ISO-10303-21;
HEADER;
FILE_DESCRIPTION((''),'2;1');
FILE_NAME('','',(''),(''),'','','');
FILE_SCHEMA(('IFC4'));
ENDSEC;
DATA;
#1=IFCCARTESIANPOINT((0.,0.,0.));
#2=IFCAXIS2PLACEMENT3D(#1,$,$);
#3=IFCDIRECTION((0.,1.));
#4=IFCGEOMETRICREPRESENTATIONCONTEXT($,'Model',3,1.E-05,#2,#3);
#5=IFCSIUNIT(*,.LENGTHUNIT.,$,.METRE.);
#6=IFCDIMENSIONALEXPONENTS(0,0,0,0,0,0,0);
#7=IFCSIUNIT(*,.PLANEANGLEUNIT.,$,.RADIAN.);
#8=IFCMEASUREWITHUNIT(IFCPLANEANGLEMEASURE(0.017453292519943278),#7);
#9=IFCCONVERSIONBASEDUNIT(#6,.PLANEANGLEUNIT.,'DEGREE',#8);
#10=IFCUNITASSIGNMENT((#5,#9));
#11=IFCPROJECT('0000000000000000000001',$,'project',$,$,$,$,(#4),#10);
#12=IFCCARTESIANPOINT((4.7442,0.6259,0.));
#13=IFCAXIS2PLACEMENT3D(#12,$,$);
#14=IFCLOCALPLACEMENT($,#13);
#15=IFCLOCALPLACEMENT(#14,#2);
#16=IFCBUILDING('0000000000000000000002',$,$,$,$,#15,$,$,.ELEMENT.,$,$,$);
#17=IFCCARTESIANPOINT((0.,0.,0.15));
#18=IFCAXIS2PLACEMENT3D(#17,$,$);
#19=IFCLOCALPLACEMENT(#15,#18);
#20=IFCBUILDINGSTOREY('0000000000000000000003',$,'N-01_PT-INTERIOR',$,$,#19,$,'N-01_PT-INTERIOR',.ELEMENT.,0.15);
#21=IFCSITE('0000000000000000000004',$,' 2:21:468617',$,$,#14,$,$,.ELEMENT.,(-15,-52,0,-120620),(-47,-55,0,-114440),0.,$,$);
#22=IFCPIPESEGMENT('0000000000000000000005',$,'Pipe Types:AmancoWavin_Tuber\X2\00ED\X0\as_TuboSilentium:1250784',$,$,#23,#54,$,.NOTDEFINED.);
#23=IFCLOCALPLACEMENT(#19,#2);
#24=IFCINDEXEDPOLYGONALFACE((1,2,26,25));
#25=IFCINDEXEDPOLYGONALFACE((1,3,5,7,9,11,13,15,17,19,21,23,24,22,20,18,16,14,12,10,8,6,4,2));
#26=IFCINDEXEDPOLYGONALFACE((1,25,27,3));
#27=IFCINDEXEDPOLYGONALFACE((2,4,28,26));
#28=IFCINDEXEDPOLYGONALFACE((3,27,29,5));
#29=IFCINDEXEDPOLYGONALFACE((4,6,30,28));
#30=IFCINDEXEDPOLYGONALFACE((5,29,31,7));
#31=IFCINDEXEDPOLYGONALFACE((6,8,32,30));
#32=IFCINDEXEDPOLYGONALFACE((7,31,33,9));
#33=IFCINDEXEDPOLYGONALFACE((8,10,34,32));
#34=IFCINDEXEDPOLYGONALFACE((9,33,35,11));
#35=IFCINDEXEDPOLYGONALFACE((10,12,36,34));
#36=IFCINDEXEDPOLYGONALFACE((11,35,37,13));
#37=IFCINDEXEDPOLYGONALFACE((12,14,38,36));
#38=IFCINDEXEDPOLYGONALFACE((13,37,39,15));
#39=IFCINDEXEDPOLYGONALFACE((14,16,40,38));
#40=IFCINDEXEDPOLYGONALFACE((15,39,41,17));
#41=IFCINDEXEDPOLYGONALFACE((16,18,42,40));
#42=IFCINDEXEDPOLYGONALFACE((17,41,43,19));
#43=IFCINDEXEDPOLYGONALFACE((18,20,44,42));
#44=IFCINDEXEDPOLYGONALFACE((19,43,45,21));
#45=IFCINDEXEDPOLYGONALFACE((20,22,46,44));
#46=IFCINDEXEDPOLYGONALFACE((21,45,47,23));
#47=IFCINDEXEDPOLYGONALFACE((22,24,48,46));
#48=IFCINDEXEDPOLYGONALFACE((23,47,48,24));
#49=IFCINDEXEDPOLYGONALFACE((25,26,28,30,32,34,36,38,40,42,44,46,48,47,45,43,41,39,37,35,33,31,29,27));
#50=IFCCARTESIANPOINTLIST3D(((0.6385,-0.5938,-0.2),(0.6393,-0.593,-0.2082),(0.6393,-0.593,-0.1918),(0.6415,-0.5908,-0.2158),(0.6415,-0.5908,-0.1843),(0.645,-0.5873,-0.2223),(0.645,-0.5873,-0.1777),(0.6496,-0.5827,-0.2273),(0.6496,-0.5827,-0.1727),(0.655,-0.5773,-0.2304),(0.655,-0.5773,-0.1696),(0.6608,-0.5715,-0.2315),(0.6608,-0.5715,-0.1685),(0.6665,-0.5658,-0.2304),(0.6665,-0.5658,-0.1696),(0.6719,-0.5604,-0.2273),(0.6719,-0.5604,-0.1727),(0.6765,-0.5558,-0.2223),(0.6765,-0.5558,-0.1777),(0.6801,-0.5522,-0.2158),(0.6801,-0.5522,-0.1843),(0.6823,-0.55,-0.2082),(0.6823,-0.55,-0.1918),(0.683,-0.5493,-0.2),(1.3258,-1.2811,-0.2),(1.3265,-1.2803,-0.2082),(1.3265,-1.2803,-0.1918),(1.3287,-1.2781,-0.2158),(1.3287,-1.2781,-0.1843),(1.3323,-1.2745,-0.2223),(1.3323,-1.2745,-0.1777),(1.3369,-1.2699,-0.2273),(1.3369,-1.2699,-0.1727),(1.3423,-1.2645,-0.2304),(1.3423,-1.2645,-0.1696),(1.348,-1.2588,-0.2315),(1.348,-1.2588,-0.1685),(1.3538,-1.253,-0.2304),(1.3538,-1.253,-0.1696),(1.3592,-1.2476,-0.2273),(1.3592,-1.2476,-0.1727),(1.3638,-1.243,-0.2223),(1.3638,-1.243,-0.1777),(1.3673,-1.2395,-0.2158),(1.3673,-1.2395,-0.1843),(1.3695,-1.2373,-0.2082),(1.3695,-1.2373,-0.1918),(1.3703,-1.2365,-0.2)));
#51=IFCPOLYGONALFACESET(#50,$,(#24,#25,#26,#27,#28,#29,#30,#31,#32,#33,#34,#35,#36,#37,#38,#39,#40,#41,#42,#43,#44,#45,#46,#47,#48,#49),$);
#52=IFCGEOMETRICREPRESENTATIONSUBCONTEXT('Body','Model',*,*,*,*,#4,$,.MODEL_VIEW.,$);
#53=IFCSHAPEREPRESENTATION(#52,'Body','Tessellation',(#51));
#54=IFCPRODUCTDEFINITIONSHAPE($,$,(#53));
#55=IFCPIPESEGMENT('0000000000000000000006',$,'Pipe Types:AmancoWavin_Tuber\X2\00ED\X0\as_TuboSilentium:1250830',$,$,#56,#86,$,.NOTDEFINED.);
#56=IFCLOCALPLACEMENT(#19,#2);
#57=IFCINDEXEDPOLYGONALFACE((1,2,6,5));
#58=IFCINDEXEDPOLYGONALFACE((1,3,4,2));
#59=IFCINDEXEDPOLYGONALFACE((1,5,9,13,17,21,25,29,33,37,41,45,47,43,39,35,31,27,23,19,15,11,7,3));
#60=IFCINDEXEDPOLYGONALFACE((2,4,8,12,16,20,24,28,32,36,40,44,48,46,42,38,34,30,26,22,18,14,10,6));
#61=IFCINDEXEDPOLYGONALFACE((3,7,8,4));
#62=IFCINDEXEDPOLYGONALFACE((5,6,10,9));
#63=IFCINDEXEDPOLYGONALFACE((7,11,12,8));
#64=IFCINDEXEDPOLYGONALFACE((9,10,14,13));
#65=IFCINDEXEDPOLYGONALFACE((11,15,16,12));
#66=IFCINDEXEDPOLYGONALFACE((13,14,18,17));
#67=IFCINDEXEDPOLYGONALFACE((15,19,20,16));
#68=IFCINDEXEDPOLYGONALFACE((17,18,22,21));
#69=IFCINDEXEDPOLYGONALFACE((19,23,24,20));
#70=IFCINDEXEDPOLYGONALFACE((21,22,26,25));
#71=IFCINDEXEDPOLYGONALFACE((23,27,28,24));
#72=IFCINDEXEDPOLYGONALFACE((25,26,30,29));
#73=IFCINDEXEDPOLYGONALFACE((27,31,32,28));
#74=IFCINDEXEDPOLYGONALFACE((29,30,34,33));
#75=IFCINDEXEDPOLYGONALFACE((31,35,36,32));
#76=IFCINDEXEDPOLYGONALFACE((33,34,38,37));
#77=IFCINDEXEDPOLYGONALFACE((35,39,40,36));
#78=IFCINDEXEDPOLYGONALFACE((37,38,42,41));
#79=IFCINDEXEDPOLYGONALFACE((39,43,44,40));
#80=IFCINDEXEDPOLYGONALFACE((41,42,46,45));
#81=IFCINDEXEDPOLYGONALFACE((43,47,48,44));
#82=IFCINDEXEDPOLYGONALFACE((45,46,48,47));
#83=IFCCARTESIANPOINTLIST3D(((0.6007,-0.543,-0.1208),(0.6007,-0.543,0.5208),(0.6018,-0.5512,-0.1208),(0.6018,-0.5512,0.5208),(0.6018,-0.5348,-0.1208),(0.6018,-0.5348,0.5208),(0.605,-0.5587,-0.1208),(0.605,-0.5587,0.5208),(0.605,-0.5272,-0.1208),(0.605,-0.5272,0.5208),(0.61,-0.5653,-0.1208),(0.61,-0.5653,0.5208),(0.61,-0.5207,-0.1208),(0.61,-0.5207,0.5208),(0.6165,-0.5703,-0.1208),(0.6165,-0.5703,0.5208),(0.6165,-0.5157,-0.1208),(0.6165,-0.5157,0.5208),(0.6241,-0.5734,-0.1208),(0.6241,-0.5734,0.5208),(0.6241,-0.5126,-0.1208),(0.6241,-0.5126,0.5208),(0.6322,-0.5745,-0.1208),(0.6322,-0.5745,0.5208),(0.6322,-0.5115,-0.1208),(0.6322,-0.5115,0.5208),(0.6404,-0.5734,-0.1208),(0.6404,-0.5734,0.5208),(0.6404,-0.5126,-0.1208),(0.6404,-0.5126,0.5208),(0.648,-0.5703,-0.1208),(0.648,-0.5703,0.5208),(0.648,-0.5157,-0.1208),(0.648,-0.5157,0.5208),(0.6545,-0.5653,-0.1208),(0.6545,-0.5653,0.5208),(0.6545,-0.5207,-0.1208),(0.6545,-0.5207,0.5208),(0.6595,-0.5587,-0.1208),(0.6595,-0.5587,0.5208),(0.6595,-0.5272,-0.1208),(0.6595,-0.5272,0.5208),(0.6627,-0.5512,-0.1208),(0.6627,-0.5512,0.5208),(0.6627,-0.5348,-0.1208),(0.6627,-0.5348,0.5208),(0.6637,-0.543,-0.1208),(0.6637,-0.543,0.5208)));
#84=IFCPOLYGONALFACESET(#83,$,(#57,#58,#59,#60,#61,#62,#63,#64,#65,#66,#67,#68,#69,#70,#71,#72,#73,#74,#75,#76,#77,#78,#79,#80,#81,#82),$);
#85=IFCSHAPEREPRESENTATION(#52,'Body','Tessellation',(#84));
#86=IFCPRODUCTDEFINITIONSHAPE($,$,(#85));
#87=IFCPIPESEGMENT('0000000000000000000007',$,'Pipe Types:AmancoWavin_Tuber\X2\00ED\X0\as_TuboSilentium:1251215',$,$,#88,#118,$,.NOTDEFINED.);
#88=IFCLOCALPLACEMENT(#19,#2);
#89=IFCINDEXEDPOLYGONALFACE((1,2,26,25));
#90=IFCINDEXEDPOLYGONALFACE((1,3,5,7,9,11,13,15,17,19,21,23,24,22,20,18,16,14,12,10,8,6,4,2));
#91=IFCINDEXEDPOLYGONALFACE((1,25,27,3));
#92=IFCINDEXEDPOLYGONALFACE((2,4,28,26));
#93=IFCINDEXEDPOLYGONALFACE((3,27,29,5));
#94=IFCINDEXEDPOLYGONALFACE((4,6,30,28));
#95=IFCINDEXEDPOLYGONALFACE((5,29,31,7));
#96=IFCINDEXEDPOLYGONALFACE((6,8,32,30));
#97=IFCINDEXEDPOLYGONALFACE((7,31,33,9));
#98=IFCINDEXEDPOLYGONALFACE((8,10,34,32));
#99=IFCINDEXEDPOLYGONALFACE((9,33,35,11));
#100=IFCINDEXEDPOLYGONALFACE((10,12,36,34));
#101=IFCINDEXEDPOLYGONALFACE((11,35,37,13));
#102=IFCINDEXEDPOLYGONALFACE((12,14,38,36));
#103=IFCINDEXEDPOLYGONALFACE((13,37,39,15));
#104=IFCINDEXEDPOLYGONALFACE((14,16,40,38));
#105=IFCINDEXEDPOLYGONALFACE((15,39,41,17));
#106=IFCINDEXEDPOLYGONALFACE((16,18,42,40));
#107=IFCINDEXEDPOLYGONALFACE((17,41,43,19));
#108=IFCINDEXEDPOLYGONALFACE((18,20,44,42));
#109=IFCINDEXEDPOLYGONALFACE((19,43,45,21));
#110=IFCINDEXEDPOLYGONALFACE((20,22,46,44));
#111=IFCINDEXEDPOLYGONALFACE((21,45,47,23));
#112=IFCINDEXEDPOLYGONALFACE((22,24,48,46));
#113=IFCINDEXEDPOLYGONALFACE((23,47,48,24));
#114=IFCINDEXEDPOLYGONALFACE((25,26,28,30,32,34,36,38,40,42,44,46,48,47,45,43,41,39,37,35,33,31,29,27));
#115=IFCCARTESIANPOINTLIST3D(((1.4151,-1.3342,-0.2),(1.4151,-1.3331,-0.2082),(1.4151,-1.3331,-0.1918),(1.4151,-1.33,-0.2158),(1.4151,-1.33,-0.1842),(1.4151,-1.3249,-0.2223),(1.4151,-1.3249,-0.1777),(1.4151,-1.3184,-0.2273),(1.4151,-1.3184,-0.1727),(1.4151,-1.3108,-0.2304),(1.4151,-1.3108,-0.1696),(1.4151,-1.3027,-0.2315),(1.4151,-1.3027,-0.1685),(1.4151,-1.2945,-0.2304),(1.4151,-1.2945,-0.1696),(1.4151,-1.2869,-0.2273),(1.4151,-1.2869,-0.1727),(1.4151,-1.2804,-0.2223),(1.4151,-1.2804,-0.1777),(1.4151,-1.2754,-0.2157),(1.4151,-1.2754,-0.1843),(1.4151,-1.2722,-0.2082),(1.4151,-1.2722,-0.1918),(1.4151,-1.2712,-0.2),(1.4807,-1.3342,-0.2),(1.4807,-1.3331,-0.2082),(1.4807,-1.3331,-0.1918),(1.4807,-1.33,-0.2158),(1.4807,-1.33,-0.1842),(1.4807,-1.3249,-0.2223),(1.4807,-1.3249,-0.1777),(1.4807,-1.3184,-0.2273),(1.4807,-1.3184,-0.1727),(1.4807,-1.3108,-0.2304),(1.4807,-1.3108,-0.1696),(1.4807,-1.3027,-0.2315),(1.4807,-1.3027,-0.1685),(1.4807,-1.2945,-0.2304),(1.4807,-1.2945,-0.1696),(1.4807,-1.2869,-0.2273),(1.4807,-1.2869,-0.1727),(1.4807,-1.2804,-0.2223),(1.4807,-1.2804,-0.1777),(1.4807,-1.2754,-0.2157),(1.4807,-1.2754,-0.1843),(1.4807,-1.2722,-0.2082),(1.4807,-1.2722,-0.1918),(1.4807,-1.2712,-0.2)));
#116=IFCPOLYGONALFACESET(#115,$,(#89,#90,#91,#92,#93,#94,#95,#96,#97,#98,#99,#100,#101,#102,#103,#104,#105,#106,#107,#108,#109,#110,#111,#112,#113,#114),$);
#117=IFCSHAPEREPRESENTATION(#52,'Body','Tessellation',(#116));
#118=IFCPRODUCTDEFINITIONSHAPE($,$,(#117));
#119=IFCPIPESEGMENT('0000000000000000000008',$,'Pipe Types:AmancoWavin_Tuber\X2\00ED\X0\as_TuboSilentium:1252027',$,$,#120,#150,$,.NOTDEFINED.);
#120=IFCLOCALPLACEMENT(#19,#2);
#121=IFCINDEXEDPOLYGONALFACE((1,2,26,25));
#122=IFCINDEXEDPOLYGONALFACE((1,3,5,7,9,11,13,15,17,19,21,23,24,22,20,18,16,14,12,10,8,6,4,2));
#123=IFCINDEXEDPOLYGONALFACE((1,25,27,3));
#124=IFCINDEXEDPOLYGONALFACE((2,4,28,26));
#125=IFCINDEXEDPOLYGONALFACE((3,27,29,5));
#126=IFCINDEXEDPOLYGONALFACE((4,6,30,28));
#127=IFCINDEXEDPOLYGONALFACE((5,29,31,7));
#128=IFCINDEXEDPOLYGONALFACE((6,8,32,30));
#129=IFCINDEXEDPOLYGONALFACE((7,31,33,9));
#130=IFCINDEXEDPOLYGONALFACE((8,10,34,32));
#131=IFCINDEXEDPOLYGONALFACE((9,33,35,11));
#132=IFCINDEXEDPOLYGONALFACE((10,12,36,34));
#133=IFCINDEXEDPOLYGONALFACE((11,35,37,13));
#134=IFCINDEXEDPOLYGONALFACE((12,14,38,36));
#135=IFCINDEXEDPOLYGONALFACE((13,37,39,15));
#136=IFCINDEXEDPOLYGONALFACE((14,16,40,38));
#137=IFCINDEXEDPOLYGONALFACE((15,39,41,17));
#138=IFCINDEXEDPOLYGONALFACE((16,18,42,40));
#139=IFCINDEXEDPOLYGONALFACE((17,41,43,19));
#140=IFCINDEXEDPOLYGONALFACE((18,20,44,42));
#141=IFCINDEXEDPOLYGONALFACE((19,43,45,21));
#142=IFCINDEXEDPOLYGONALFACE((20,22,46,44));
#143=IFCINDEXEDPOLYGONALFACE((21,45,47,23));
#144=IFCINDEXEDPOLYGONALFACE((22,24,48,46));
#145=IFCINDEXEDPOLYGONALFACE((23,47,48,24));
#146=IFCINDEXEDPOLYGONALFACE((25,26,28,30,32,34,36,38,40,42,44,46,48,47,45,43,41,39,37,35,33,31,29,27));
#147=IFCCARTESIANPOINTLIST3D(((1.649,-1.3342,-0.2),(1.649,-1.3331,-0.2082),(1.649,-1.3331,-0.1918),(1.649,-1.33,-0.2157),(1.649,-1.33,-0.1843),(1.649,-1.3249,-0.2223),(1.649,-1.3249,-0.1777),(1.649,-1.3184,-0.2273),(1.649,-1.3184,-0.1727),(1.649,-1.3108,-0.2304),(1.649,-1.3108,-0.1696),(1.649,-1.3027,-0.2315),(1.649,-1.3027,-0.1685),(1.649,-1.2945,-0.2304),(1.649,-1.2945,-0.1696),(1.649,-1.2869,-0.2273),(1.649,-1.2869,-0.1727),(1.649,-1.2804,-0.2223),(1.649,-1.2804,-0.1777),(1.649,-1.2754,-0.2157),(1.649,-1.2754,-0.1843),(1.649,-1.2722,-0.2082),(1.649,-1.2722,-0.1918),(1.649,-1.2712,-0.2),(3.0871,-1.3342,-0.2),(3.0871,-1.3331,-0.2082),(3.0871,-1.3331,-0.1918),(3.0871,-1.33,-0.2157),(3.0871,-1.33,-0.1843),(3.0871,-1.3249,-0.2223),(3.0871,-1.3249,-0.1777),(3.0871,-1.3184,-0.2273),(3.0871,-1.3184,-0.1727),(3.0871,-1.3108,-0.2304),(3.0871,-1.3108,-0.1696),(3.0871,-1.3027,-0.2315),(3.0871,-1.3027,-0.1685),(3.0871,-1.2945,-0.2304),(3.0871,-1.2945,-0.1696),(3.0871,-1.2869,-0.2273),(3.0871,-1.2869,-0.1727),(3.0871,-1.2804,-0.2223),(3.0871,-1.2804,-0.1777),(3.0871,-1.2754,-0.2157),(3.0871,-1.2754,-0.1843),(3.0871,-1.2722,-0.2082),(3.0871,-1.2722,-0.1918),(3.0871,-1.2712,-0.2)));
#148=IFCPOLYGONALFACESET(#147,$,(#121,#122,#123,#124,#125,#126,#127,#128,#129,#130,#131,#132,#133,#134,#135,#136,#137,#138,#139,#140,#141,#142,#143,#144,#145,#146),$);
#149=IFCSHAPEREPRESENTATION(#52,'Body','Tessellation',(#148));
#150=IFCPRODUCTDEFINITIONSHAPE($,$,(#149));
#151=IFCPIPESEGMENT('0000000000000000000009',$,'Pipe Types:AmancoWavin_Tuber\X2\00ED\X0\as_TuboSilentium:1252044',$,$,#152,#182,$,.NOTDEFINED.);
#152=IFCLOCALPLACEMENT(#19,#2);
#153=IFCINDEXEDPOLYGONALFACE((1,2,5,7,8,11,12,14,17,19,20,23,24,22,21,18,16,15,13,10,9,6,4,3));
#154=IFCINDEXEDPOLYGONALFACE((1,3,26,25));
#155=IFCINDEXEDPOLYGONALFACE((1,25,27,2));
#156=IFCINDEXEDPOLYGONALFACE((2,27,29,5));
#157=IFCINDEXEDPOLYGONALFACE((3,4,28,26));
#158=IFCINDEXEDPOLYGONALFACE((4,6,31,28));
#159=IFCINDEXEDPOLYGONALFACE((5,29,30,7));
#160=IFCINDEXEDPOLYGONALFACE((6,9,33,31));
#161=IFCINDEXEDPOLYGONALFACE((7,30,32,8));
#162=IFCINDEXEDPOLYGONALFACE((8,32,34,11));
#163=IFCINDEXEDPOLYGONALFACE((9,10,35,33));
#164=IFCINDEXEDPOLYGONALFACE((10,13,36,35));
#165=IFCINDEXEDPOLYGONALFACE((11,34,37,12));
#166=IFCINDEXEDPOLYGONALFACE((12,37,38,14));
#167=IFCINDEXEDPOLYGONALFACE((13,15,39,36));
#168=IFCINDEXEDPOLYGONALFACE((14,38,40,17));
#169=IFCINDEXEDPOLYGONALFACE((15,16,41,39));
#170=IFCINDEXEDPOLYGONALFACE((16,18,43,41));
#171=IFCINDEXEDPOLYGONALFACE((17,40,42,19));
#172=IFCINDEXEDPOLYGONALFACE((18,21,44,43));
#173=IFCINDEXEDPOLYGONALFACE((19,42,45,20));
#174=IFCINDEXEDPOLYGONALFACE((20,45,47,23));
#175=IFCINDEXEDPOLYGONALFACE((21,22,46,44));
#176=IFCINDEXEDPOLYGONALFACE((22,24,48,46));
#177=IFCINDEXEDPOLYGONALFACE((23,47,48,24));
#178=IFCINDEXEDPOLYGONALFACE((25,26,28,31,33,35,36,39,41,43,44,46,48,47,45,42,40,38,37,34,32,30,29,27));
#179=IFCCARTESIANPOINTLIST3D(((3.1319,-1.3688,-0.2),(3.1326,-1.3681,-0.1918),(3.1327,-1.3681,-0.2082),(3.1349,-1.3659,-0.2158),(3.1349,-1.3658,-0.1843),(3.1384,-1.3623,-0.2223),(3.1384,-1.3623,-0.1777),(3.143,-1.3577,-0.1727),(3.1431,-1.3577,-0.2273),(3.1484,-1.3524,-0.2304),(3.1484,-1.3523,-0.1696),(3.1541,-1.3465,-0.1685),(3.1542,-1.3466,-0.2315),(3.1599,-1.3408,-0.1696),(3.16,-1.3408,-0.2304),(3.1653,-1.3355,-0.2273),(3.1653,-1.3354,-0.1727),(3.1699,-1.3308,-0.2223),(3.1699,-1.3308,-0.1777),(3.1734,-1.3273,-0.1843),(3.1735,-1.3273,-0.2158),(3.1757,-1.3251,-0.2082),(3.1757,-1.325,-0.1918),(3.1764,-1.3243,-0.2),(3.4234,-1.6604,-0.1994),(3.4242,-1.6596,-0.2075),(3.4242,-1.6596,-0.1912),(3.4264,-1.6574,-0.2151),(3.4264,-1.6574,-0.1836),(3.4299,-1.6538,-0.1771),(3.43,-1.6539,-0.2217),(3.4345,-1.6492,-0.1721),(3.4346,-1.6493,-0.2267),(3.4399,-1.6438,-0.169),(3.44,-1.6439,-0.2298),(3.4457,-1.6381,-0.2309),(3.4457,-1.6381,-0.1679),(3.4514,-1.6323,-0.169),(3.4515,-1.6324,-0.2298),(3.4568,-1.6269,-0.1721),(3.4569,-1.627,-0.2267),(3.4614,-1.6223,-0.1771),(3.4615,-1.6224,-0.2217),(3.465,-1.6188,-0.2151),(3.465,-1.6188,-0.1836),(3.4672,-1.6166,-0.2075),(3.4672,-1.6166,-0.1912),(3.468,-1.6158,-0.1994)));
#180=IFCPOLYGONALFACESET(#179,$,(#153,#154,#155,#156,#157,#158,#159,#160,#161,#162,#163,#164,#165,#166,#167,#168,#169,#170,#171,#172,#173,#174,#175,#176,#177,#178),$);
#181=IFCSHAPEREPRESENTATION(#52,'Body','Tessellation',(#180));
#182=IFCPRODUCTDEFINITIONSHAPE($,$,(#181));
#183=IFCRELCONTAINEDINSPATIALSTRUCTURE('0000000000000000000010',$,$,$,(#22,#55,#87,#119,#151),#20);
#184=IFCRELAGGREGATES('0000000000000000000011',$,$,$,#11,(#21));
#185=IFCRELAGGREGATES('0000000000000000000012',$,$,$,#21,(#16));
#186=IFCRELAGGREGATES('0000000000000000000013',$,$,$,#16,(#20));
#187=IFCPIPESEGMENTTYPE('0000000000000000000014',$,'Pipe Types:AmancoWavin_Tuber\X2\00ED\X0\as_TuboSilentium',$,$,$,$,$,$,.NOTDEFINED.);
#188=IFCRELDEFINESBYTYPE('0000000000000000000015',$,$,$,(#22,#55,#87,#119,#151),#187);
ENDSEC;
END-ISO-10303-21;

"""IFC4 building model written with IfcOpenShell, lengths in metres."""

from ifc_helpers import new_model, entity, si_unit, converted_unit, direction, frame, origin, place, context, subcontext, project, spatial, arc, indexed_curve, outline, extrude, type_object, element, save


model = new_model("IFC4")

# Units and contexts
model_context = context("Model", 3, precision=1e-05, world=origin(), true_north=direction((0.0, 1.0)))
body_context = subcontext(model_context, "Body", "Model", "MODEL_VIEW")
ifc_project = project(units=[si_unit("LENGTHUNIT", "METRE"), converted_unit("PLANEANGLEUNIT", "DEGREE", entity("IfcPlaneAngleMeasure", 0.017453292519943278), si_unit("PLANEANGLEUNIT", "RADIAN"), dimensions=[0, 0, 0, 0, 0, 0, 0])], contexts=[model_context])

# Site, building, storey
site_placement = place(None, frame((4.7442, 0.6259, 0.0)))
site = spatial("IfcSite", under=ifc_project, at=site_placement, Name=" 2:21:468617", CompositionType="ELEMENT", RefLatitude=(-15, -52, 0, -120620), RefLongitude=(-47, -55, 0, -114440), RefElevation=0.0)
building_placement = place(site_placement, origin())
building = spatial("IfcBuilding", under=site, at=building_placement, CompositionType="ELEMENT")
storey_placement = place(building_placement, frame((0.0, 0.0, 0.15)))
storey = spatial("IfcBuildingStorey", under=building, at=storey_placement, Name="N-01_PT-INTERIOR", LongName="N-01_PT-INTERIOR", CompositionType="ELEMENT", Elevation=0.15)

# Pipe segments
pipe_segment_type_1 = type_object("IfcPipeSegmentType", Name="Pipe Types:AmancoWavin_Tuberías_TuboSilentium", PredefinedType="NOTDEFINED")
pipe_segment_1_placement = place(storey_placement, origin())
element("IfcPipeSegment", 1, at=pipe_segment_1_placement, inside=storey, type_object=pipe_segment_type_1, Name="Pipe Types:AmancoWavin_Tuberías_TuboSilentium:1250784", PredefinedType="NOTDEFINED", context=body_context, shape_type="SweptSolid", body=[
    extrude(outline(indexed_curve([(0.0315, 0.0), (0.0223, 0.0223), (0.0, 0.0315), (-0.0223, 0.0223), (-0.0315, 0.0), (-0.0223, -0.0223), (0.0, -0.0315), (0.0223, -0.0223)], segments=[arc(1, 2, 3), arc(3, 4, 5), arc(5, 6, 7), arc(7, 8, 1)], self_intersect=False)), frame((1.348, -1.2588, -0.2), z_axis=(-0.707107, 0.707107, 0.0), x_axis=(0.707107, 0.707107, 0.0)), (0.0, 0.0, 1.0), 0.9719),
])
pipe_segment_2_placement = place(storey_placement, origin())
element("IfcPipeSegment", 2, at=pipe_segment_2_placement, inside=storey, type_object=pipe_segment_type_1, Name="Pipe Types:AmancoWavin_Tuberías_TuboSilentium:1250830", PredefinedType="NOTDEFINED", context=body_context, shape_type="SweptSolid", body=[
    extrude(outline(indexed_curve([(0.0315, 0.0), (0.0223, 0.0223), (0.0, 0.0315), (-0.0223, 0.0223), (-0.0315, 0.0), (-0.0223, -0.0223), (0.0, -0.0315), (0.0223, -0.0223)], segments=[arc(1, 2, 3), arc(3, 4, 5), arc(5, 6, 7), arc(7, 8, 1)], self_intersect=False)), frame((0.6322, -0.543, -0.1208), z_axis=(0.0, 0.0, 1.0), x_axis=(-1.0, 0.0, 0.0)), (0.0, 0.0, 1.0), 0.6416),
])
pipe_segment_3_placement = place(storey_placement, origin())
element("IfcPipeSegment", 3, at=pipe_segment_3_placement, inside=storey, type_object=pipe_segment_type_1, Name="Pipe Types:AmancoWavin_Tuberías_TuboSilentium:1251215", PredefinedType="NOTDEFINED", context=body_context, shape_type="SweptSolid", body=[
    extrude(outline(indexed_curve([(0.0315, 0.0), (0.0223, 0.0223), (0.0, 0.0315), (-0.0223, 0.0223), (-0.0315, 0.0), (-0.0223, -0.0223), (0.0, -0.0315), (0.0223, -0.0223)], segments=[arc(1, 2, 3), arc(3, 4, 5), arc(5, 6, 7), arc(7, 8, 1)], self_intersect=False)), frame((1.4151, -1.3027, -0.2), z_axis=(1.0, 0.0, 0.0), x_axis=(0.0, 1.0, 0.0)), (0.0, 0.0, 1.0), 0.0656),
])
pipe_segment_4_placement = place(storey_placement, origin())
element("IfcPipeSegment", 4, at=pipe_segment_4_placement, inside=storey, type_object=pipe_segment_type_1, Name="Pipe Types:AmancoWavin_Tuberías_TuboSilentium:1252027", PredefinedType="NOTDEFINED", context=body_context, shape_type="SweptSolid", body=[
    extrude(outline(indexed_curve([(0.0315, 0.0), (0.0223, 0.0223), (0.0, 0.0315), (-0.0223, 0.0223), (-0.0315, 0.0), (-0.0223, -0.0223), (0.0, -0.0315), (0.0223, -0.0223)], segments=[arc(1, 2, 3), arc(3, 4, 5), arc(5, 6, 7), arc(7, 8, 1)], self_intersect=False)), frame((1.649, -1.3027, -0.2), z_axis=(1.0, 0.0, 0.0), x_axis=(0.0, -1.0, 0.0)), (0.0, 0.0, 1.0), 1.438),
])
pipe_segment_5_placement = place(storey_placement, origin())
element("IfcPipeSegment", 5, at=pipe_segment_5_placement, inside=storey, type_object=pipe_segment_type_1, Name="Pipe Types:AmancoWavin_Tuberías_TuboSilentium:1252044", PredefinedType="NOTDEFINED", context=body_context, shape_type="SweptSolid", body=[
    extrude(outline(indexed_curve([(0.0315, 0.0), (0.0223, 0.0223), (0.0, 0.0315), (-0.0223, 0.0223), (-0.0315, 0.0), (-0.0223, -0.0223), (0.0, -0.0315), (0.0223, -0.0223)], segments=[arc(1, 2, 3), arc(3, 4, 5), arc(5, 6, 7), arc(7, 8, 1)], self_intersect=False)), frame((3.1542, -1.3466, -0.2), z_axis=(0.707106, -0.707106, 0.001478), x_axis=(-0.707107, -0.707107, 0.0)), (0.0, 0.0, 1.0), 0.4123),
])

save(model, "model.ifc")
